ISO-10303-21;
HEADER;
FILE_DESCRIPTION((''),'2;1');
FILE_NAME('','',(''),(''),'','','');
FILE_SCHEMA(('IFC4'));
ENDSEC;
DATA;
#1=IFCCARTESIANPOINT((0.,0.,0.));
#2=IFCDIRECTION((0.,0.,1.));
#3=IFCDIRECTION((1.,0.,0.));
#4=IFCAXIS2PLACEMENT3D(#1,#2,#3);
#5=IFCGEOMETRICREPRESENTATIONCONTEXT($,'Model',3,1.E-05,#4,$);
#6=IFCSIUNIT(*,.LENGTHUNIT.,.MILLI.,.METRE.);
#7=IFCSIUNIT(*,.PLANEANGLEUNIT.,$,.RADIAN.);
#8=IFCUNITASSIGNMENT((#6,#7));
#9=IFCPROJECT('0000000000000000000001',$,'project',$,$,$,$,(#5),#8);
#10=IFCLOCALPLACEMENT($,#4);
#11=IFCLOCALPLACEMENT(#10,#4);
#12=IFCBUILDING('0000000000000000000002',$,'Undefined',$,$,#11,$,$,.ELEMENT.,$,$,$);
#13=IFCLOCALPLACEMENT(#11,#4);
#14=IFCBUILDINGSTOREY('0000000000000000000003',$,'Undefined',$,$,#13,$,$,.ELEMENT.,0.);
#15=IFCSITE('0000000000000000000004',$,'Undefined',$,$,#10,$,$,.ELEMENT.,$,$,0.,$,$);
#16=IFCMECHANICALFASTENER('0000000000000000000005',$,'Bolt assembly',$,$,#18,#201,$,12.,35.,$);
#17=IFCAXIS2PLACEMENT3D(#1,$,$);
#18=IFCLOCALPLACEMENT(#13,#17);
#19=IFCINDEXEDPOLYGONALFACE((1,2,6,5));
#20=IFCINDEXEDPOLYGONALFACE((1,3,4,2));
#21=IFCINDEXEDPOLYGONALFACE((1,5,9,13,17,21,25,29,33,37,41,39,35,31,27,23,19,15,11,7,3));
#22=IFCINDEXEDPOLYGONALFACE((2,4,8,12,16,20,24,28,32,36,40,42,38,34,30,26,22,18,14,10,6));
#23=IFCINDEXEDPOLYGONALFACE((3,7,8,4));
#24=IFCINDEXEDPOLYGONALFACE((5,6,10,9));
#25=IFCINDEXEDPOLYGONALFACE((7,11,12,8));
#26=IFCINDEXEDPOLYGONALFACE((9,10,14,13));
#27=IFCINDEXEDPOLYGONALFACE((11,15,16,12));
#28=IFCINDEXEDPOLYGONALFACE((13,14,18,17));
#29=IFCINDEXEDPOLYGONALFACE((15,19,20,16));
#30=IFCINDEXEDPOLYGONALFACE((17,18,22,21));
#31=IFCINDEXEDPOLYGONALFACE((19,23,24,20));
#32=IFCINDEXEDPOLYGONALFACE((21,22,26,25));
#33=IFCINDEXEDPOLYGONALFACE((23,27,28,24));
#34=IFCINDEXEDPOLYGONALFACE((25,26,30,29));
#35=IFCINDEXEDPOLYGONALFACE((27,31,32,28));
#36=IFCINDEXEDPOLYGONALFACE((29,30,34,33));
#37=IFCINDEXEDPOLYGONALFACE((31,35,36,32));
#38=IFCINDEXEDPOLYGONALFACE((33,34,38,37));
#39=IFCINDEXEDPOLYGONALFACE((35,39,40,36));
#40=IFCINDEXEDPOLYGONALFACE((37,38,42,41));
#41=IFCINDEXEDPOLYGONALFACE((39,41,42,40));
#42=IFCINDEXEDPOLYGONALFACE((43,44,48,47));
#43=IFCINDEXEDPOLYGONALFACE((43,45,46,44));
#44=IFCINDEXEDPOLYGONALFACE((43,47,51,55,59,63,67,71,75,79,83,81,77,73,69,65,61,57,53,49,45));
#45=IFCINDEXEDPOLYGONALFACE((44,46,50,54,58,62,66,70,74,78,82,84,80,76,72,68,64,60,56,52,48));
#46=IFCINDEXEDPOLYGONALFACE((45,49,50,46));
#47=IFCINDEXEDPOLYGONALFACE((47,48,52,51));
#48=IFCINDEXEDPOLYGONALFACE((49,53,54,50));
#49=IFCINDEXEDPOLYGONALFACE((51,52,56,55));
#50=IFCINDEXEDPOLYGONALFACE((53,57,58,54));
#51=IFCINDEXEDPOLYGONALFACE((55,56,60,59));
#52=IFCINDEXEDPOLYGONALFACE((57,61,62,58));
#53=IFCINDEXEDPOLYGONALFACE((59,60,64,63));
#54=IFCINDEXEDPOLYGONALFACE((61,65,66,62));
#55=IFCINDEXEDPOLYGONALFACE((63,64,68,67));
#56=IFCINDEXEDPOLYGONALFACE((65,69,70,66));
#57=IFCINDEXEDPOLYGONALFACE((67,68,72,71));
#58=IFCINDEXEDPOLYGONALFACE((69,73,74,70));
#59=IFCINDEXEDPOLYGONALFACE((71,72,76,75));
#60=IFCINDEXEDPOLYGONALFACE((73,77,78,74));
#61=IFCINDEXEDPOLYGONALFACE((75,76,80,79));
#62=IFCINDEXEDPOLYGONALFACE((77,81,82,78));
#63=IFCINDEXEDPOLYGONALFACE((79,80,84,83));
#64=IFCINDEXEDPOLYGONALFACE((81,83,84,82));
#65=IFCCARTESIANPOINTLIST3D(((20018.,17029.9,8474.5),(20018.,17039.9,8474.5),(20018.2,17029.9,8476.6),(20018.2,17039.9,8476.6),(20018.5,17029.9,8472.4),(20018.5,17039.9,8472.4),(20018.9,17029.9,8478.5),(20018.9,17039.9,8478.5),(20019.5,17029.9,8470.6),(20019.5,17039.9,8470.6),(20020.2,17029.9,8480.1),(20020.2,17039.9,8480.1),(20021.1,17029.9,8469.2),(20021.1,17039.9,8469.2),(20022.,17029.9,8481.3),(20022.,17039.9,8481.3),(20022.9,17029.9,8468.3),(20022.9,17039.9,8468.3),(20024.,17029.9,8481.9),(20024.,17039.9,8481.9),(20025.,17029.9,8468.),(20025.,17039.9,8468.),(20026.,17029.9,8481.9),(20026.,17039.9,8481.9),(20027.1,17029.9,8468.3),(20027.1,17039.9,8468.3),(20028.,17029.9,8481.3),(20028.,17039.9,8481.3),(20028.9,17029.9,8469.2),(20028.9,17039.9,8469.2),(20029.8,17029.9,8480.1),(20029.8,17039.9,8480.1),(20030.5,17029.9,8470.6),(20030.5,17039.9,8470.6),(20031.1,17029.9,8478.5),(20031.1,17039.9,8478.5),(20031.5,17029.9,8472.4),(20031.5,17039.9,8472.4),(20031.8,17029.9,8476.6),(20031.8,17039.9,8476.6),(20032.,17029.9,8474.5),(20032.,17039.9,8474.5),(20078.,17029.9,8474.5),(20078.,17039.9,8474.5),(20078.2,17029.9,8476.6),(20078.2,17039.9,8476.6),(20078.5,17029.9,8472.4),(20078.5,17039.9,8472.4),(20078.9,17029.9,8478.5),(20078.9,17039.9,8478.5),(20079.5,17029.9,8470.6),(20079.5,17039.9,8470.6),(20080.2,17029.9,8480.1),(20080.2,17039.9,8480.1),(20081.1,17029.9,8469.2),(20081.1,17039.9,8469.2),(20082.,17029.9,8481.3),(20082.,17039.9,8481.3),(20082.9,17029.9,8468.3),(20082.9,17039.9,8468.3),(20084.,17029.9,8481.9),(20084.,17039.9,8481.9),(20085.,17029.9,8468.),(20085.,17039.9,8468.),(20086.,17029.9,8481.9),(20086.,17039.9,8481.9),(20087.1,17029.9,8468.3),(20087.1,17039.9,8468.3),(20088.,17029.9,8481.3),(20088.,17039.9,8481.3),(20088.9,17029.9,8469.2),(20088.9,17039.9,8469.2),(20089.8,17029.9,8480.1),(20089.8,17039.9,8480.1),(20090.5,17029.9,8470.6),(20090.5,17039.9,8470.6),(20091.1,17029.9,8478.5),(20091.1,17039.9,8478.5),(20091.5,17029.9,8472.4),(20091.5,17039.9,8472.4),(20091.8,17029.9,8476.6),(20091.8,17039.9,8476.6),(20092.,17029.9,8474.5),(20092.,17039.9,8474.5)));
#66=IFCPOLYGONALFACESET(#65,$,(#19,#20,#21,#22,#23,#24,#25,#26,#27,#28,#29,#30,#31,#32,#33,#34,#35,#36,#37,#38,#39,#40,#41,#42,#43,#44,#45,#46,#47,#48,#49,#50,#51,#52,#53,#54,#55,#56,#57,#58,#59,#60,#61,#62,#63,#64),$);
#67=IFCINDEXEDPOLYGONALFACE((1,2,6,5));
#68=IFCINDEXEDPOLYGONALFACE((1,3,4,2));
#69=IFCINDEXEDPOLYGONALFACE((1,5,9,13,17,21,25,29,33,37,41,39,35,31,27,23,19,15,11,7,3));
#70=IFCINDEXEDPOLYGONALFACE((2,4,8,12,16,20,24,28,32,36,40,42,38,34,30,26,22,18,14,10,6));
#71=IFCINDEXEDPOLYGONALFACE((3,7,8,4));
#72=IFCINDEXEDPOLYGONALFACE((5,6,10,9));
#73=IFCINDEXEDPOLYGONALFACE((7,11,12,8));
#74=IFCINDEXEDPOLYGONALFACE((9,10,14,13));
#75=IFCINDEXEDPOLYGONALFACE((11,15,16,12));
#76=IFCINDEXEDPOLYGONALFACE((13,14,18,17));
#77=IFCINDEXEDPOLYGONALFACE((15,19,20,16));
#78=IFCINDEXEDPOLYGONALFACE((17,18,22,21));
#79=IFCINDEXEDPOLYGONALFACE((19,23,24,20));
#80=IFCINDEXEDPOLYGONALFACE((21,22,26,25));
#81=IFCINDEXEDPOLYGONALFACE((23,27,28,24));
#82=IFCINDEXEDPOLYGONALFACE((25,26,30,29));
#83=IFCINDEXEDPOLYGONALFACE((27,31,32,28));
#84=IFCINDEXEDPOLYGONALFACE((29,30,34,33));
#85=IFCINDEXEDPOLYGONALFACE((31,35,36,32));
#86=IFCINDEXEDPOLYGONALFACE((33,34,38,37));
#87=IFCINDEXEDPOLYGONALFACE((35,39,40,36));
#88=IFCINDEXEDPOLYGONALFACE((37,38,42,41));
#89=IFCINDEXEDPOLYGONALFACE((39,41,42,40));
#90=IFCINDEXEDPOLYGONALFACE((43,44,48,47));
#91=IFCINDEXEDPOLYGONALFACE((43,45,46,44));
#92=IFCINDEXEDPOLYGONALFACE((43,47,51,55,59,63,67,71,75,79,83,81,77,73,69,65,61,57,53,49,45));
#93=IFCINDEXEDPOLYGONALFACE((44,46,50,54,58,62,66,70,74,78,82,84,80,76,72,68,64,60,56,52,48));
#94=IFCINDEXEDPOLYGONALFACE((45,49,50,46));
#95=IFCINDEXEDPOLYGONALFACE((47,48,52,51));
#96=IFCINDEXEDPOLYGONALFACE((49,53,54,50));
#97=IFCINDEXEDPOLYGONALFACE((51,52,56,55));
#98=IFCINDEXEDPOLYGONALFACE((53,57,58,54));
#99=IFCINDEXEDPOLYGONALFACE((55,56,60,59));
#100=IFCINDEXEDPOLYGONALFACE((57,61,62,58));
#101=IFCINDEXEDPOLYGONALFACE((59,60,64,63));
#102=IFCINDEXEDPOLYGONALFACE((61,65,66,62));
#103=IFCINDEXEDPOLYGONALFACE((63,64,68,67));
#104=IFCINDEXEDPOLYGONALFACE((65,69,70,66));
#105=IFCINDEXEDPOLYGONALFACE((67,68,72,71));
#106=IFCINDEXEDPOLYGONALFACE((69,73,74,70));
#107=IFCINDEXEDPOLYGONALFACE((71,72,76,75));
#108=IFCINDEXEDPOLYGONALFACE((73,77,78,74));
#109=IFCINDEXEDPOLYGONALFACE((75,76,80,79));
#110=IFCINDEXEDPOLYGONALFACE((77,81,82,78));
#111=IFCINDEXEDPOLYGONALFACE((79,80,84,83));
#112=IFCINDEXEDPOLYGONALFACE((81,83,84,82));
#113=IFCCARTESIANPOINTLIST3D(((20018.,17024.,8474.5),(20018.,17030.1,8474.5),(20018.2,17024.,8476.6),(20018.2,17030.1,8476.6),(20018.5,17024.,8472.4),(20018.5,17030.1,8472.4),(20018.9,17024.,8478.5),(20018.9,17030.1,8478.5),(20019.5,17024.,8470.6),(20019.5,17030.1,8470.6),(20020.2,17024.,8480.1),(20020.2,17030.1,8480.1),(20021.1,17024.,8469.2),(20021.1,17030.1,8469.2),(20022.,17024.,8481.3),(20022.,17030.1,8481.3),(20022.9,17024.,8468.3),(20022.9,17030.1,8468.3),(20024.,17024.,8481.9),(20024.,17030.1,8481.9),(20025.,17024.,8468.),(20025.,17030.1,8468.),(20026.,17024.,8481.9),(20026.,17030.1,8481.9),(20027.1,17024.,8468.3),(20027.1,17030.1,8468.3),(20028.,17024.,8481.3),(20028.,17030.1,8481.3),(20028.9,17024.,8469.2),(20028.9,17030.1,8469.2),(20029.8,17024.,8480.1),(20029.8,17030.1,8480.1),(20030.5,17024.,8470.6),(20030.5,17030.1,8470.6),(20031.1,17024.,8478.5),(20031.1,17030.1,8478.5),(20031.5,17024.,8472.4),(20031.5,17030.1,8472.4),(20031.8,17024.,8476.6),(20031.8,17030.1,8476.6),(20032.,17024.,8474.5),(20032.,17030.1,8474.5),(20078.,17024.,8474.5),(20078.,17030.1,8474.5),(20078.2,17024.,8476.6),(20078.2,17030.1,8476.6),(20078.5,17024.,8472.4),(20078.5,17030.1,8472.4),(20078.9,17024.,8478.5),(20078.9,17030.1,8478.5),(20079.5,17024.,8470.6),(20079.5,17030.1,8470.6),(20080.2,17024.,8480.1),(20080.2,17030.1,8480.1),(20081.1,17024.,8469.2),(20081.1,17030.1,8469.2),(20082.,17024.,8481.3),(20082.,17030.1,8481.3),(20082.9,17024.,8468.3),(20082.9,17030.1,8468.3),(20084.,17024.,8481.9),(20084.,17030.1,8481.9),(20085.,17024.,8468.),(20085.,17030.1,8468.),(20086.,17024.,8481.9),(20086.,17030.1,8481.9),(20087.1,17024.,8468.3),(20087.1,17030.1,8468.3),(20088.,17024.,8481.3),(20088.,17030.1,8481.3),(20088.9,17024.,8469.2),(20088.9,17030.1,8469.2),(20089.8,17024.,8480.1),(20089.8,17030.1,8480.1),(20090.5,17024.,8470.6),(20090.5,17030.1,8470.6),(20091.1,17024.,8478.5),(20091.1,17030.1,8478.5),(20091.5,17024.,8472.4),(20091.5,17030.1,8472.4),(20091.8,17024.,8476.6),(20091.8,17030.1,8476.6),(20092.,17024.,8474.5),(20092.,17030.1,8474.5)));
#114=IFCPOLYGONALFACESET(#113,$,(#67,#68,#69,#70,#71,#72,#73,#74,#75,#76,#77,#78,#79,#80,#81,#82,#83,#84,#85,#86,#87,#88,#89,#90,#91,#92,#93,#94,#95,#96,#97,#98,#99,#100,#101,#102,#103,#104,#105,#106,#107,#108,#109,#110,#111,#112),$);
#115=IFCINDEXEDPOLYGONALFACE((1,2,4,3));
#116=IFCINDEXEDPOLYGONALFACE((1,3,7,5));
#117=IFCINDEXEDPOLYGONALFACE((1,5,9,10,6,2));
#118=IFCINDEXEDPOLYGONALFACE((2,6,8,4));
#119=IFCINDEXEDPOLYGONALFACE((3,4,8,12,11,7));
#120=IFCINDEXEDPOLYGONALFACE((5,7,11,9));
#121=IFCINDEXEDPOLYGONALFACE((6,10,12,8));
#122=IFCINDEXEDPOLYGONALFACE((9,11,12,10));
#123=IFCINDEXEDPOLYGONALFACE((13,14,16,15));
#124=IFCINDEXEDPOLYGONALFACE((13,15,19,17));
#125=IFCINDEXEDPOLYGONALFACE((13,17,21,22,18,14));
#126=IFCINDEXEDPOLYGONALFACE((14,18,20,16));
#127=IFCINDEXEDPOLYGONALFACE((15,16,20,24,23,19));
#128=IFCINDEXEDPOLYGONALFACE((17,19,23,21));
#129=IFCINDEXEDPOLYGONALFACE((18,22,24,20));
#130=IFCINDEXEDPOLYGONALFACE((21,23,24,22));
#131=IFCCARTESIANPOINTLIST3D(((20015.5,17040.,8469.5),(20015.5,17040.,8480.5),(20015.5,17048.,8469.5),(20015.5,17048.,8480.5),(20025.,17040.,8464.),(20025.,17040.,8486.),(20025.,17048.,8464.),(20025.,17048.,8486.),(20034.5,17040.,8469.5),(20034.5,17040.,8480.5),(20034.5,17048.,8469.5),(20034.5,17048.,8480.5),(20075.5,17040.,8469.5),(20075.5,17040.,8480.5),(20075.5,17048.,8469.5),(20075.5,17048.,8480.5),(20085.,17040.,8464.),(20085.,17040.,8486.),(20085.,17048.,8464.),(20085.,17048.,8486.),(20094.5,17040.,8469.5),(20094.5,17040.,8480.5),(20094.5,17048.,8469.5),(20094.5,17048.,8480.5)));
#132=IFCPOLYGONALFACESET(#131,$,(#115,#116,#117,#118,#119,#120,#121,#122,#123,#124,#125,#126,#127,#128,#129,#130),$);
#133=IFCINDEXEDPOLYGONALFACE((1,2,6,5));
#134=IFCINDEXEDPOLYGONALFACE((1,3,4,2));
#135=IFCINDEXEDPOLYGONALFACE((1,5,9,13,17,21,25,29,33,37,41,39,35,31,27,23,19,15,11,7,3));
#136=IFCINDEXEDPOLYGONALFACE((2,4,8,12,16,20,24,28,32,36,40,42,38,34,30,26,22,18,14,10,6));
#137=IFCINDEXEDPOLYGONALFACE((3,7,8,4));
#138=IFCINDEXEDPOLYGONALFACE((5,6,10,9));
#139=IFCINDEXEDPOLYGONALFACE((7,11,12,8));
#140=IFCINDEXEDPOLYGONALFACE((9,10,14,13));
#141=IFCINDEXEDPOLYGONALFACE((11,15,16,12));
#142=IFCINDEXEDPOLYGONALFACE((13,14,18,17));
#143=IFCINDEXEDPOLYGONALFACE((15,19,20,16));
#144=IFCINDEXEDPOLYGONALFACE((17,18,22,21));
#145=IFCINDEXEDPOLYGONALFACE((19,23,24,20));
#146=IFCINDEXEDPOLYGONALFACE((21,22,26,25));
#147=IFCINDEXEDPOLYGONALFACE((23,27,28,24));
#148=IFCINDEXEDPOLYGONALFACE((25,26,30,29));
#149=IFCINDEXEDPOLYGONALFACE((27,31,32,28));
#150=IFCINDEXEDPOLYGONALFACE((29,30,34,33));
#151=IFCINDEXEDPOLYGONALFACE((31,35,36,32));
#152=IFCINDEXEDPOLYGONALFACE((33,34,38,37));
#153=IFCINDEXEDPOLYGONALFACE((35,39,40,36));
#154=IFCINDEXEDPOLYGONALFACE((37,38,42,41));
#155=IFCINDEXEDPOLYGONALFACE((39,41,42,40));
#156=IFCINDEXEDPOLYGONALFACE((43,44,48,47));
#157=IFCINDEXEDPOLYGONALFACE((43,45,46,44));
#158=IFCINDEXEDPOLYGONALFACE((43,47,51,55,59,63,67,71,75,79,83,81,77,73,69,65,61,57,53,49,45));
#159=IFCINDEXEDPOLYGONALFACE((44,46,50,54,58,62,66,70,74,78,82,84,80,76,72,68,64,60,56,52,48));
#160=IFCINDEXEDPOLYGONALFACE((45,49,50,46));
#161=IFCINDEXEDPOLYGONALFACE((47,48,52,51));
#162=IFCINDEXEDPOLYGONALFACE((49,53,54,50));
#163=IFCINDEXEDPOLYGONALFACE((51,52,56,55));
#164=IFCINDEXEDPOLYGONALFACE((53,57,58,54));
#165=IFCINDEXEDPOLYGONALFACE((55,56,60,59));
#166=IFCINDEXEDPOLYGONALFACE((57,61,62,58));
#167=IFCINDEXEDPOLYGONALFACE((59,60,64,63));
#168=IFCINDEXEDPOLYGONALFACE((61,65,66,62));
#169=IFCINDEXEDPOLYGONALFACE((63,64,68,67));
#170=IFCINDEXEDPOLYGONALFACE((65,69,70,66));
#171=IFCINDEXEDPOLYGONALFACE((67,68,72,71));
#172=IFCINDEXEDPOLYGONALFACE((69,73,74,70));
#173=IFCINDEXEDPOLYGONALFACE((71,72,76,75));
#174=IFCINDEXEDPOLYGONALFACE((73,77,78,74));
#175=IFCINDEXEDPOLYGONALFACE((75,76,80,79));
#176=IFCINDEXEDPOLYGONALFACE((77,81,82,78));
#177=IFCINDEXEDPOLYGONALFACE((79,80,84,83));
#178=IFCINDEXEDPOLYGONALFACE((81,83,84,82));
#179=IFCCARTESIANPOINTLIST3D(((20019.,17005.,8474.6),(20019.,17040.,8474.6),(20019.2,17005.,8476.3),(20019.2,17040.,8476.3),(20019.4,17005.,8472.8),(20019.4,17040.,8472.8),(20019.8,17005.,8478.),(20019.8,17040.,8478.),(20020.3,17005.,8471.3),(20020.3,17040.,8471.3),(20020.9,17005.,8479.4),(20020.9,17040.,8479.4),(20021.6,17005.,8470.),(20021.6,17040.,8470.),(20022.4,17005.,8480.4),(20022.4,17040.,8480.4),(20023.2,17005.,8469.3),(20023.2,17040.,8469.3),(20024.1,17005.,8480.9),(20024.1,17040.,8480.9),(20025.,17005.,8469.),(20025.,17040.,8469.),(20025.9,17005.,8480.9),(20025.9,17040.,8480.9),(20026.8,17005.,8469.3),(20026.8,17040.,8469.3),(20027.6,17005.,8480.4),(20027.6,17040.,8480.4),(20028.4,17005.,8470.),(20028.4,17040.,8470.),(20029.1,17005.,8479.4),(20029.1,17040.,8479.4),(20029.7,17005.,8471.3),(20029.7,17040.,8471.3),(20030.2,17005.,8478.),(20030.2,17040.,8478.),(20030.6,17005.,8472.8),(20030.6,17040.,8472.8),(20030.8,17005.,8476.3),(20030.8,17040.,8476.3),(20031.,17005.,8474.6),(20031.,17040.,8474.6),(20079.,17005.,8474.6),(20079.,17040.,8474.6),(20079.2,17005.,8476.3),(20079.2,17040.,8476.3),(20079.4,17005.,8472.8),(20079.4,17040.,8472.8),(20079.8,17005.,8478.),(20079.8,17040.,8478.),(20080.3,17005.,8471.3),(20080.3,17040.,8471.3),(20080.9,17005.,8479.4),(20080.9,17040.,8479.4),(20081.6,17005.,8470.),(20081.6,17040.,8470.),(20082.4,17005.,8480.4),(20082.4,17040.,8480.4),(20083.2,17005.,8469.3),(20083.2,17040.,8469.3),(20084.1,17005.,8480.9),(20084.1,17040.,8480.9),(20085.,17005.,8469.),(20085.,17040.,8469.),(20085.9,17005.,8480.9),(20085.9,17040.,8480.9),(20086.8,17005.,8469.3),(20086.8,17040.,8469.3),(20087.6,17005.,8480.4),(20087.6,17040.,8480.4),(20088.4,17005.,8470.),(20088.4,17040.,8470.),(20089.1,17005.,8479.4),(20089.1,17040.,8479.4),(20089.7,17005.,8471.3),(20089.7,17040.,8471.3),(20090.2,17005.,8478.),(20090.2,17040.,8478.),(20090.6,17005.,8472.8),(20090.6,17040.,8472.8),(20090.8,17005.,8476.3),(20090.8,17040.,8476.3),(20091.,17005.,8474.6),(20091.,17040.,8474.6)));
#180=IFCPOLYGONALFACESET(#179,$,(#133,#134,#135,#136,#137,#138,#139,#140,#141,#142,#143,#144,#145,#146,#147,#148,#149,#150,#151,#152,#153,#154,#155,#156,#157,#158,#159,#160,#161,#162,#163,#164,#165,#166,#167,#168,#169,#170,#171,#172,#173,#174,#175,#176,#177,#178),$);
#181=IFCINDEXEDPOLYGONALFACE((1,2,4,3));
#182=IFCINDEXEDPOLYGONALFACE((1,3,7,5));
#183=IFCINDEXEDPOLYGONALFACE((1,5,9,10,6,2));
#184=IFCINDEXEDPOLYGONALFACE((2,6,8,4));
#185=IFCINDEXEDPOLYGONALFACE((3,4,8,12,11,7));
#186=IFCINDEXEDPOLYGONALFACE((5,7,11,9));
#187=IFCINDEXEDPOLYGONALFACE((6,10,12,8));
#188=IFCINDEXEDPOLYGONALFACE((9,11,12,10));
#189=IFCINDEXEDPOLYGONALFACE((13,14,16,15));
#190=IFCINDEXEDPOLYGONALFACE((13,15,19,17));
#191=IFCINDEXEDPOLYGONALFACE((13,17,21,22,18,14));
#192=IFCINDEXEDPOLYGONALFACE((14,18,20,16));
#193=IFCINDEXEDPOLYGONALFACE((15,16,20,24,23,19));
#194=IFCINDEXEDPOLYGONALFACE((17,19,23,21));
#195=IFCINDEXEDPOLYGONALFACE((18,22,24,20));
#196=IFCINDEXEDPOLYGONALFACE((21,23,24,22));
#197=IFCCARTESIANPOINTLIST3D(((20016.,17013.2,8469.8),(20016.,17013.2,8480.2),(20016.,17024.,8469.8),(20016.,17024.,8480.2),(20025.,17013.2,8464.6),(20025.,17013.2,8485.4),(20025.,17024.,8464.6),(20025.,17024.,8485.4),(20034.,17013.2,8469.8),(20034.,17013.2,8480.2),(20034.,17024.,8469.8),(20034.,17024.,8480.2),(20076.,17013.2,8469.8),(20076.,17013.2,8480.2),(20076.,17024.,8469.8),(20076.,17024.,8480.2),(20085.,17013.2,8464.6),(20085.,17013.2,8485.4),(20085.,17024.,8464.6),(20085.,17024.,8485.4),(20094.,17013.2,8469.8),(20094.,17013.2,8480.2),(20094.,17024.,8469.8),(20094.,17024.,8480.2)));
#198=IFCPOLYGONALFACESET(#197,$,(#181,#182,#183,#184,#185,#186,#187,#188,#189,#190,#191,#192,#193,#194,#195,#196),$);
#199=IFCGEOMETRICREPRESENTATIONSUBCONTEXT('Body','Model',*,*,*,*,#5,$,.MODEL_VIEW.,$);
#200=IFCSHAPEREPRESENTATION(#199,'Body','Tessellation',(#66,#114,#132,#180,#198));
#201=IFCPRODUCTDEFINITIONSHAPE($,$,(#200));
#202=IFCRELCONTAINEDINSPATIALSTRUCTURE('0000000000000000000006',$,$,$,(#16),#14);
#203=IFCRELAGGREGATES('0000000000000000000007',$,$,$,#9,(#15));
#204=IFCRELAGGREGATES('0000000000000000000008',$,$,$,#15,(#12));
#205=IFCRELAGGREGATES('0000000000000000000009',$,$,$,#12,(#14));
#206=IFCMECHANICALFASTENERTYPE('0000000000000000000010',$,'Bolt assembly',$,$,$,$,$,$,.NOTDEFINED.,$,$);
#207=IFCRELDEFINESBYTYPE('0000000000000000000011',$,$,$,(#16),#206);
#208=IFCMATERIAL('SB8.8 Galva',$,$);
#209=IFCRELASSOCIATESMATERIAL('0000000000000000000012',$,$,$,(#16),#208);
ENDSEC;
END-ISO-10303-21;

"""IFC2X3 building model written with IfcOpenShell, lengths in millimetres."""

from ifc_helpers import new_model, si_unit, frame, origin_with_axes, origin_2d_with_axis, place, context, subcontext, project, spatial, polyline, circle, outline, extrude, source, transform, mapped, material, type_object, element, save


model = new_model("IFC2X3")

# Units and contexts
model_context = context("Model", 3, precision=1e-05, world=origin_with_axes())
body_context = subcontext(model_context, "Body", "Model", "MODEL_VIEW")
ifc_project = project(units=[si_unit("LENGTHUNIT", "METRE", prefix="MILLI"), si_unit("PLANEANGLEUNIT", "RADIAN")], contexts=[model_context])

# Site, building, storey
site_placement = place(None, origin_with_axes())
site = spatial("IfcSite", under=ifc_project, at=site_placement, Name="Undefined", CompositionType="ELEMENT", RefElevation=0.0)
building_placement = place(site_placement, origin_with_axes())
building = spatial("IfcBuilding", under=site, at=building_placement, Name="Undefined", CompositionType="ELEMENT")
storey_placement = place(building_placement, origin_with_axes())
storey = spatial("IfcBuildingStorey", under=building, at=storey_placement, Name="Undefined", CompositionType="ELEMENT", Elevation=0.0)

# Mechanical fastener
mechanical_fastener_type = type_object("IfcMechanicalFastenerType", Name="Bolt assembly")
ifc_material_1 = material(Name="SB8.8 Galva")
shared_shape_1 = source(origin_with_axes(), body_context, "Body", "SweptSolid", [
    extrude(circle(Radius=7.0, at=origin_2d_with_axis()), frame((0.0, -9.9, 0.0), z_axis=(0.0, 1.0, 0.0), x_axis=(1.0, 0.0, 0.0)), (0.0, 0.0, 1.0), 10.0),
    extrude(circle(Radius=7.0, at=origin_2d_with_axis()), frame((0.0, -0.1, 0.0), z_axis=(0.0, 1.0, 0.0), x_axis=(1.0, 0.0, 0.0)), (0.0, 0.0, 1.0), 6.1),
    extrude(outline(polyline([(11.0, 0.0), (5.5, 9.5), (-5.5, 9.5), (-11.0, 0.0), (-5.5, -9.5), (5.5, -9.5), (11.0, 0.0)])), frame((0.0, -18.0, 0.0), z_axis=(0.0, 1.0, 0.0), x_axis=(1.0, 0.0, 0.0)), (0.0, 0.0, 1.0), 8.0),
    extrude(circle(Radius=6.0, at=origin_2d_with_axis()), frame((0.0, -10.0, 0.0), z_axis=(0.0, 1.0, 0.0), x_axis=(1.0, 0.0, 0.0)), (0.0, 0.0, 1.0), 35.0),
    extrude(outline(polyline([(10.4, 0.0), (5.2, 9.0), (-5.2, 9.0), (-10.4, 0.0), (-5.2, -9.0), (5.2, -9.0), (10.4, 0.0)])), frame((0.0, 6.0, 0.0), z_axis=(0.0, 1.0, 0.0), x_axis=(1.0, 0.0, 0.0)), (0.0, 0.0, 1.0), 10.8),
])
mechanical_fastener_1_placement = place(storey_placement, frame((20055.0, 17030.0, 8475.0), z_axis=(-1.0, 0.0, 0.0), x_axis=(0.0, 0.0, -1.0)))
element("IfcMechanicalFastener", 1, at=mechanical_fastener_1_placement, inside=storey, type_object=mechanical_fastener_type, material=ifc_material_1, Name="Bolt assembly", NominalDiameter=12.0, NominalLength=35.0, context=body_context, shape_type="MappedRepresentation", body=[
    mapped(shared_shape_1, transform((0.0, 0.0, -30.0))),
    mapped(shared_shape_1, transform((0.0, 0.0, 30.0))),
])

save(model, "model.ifc")
